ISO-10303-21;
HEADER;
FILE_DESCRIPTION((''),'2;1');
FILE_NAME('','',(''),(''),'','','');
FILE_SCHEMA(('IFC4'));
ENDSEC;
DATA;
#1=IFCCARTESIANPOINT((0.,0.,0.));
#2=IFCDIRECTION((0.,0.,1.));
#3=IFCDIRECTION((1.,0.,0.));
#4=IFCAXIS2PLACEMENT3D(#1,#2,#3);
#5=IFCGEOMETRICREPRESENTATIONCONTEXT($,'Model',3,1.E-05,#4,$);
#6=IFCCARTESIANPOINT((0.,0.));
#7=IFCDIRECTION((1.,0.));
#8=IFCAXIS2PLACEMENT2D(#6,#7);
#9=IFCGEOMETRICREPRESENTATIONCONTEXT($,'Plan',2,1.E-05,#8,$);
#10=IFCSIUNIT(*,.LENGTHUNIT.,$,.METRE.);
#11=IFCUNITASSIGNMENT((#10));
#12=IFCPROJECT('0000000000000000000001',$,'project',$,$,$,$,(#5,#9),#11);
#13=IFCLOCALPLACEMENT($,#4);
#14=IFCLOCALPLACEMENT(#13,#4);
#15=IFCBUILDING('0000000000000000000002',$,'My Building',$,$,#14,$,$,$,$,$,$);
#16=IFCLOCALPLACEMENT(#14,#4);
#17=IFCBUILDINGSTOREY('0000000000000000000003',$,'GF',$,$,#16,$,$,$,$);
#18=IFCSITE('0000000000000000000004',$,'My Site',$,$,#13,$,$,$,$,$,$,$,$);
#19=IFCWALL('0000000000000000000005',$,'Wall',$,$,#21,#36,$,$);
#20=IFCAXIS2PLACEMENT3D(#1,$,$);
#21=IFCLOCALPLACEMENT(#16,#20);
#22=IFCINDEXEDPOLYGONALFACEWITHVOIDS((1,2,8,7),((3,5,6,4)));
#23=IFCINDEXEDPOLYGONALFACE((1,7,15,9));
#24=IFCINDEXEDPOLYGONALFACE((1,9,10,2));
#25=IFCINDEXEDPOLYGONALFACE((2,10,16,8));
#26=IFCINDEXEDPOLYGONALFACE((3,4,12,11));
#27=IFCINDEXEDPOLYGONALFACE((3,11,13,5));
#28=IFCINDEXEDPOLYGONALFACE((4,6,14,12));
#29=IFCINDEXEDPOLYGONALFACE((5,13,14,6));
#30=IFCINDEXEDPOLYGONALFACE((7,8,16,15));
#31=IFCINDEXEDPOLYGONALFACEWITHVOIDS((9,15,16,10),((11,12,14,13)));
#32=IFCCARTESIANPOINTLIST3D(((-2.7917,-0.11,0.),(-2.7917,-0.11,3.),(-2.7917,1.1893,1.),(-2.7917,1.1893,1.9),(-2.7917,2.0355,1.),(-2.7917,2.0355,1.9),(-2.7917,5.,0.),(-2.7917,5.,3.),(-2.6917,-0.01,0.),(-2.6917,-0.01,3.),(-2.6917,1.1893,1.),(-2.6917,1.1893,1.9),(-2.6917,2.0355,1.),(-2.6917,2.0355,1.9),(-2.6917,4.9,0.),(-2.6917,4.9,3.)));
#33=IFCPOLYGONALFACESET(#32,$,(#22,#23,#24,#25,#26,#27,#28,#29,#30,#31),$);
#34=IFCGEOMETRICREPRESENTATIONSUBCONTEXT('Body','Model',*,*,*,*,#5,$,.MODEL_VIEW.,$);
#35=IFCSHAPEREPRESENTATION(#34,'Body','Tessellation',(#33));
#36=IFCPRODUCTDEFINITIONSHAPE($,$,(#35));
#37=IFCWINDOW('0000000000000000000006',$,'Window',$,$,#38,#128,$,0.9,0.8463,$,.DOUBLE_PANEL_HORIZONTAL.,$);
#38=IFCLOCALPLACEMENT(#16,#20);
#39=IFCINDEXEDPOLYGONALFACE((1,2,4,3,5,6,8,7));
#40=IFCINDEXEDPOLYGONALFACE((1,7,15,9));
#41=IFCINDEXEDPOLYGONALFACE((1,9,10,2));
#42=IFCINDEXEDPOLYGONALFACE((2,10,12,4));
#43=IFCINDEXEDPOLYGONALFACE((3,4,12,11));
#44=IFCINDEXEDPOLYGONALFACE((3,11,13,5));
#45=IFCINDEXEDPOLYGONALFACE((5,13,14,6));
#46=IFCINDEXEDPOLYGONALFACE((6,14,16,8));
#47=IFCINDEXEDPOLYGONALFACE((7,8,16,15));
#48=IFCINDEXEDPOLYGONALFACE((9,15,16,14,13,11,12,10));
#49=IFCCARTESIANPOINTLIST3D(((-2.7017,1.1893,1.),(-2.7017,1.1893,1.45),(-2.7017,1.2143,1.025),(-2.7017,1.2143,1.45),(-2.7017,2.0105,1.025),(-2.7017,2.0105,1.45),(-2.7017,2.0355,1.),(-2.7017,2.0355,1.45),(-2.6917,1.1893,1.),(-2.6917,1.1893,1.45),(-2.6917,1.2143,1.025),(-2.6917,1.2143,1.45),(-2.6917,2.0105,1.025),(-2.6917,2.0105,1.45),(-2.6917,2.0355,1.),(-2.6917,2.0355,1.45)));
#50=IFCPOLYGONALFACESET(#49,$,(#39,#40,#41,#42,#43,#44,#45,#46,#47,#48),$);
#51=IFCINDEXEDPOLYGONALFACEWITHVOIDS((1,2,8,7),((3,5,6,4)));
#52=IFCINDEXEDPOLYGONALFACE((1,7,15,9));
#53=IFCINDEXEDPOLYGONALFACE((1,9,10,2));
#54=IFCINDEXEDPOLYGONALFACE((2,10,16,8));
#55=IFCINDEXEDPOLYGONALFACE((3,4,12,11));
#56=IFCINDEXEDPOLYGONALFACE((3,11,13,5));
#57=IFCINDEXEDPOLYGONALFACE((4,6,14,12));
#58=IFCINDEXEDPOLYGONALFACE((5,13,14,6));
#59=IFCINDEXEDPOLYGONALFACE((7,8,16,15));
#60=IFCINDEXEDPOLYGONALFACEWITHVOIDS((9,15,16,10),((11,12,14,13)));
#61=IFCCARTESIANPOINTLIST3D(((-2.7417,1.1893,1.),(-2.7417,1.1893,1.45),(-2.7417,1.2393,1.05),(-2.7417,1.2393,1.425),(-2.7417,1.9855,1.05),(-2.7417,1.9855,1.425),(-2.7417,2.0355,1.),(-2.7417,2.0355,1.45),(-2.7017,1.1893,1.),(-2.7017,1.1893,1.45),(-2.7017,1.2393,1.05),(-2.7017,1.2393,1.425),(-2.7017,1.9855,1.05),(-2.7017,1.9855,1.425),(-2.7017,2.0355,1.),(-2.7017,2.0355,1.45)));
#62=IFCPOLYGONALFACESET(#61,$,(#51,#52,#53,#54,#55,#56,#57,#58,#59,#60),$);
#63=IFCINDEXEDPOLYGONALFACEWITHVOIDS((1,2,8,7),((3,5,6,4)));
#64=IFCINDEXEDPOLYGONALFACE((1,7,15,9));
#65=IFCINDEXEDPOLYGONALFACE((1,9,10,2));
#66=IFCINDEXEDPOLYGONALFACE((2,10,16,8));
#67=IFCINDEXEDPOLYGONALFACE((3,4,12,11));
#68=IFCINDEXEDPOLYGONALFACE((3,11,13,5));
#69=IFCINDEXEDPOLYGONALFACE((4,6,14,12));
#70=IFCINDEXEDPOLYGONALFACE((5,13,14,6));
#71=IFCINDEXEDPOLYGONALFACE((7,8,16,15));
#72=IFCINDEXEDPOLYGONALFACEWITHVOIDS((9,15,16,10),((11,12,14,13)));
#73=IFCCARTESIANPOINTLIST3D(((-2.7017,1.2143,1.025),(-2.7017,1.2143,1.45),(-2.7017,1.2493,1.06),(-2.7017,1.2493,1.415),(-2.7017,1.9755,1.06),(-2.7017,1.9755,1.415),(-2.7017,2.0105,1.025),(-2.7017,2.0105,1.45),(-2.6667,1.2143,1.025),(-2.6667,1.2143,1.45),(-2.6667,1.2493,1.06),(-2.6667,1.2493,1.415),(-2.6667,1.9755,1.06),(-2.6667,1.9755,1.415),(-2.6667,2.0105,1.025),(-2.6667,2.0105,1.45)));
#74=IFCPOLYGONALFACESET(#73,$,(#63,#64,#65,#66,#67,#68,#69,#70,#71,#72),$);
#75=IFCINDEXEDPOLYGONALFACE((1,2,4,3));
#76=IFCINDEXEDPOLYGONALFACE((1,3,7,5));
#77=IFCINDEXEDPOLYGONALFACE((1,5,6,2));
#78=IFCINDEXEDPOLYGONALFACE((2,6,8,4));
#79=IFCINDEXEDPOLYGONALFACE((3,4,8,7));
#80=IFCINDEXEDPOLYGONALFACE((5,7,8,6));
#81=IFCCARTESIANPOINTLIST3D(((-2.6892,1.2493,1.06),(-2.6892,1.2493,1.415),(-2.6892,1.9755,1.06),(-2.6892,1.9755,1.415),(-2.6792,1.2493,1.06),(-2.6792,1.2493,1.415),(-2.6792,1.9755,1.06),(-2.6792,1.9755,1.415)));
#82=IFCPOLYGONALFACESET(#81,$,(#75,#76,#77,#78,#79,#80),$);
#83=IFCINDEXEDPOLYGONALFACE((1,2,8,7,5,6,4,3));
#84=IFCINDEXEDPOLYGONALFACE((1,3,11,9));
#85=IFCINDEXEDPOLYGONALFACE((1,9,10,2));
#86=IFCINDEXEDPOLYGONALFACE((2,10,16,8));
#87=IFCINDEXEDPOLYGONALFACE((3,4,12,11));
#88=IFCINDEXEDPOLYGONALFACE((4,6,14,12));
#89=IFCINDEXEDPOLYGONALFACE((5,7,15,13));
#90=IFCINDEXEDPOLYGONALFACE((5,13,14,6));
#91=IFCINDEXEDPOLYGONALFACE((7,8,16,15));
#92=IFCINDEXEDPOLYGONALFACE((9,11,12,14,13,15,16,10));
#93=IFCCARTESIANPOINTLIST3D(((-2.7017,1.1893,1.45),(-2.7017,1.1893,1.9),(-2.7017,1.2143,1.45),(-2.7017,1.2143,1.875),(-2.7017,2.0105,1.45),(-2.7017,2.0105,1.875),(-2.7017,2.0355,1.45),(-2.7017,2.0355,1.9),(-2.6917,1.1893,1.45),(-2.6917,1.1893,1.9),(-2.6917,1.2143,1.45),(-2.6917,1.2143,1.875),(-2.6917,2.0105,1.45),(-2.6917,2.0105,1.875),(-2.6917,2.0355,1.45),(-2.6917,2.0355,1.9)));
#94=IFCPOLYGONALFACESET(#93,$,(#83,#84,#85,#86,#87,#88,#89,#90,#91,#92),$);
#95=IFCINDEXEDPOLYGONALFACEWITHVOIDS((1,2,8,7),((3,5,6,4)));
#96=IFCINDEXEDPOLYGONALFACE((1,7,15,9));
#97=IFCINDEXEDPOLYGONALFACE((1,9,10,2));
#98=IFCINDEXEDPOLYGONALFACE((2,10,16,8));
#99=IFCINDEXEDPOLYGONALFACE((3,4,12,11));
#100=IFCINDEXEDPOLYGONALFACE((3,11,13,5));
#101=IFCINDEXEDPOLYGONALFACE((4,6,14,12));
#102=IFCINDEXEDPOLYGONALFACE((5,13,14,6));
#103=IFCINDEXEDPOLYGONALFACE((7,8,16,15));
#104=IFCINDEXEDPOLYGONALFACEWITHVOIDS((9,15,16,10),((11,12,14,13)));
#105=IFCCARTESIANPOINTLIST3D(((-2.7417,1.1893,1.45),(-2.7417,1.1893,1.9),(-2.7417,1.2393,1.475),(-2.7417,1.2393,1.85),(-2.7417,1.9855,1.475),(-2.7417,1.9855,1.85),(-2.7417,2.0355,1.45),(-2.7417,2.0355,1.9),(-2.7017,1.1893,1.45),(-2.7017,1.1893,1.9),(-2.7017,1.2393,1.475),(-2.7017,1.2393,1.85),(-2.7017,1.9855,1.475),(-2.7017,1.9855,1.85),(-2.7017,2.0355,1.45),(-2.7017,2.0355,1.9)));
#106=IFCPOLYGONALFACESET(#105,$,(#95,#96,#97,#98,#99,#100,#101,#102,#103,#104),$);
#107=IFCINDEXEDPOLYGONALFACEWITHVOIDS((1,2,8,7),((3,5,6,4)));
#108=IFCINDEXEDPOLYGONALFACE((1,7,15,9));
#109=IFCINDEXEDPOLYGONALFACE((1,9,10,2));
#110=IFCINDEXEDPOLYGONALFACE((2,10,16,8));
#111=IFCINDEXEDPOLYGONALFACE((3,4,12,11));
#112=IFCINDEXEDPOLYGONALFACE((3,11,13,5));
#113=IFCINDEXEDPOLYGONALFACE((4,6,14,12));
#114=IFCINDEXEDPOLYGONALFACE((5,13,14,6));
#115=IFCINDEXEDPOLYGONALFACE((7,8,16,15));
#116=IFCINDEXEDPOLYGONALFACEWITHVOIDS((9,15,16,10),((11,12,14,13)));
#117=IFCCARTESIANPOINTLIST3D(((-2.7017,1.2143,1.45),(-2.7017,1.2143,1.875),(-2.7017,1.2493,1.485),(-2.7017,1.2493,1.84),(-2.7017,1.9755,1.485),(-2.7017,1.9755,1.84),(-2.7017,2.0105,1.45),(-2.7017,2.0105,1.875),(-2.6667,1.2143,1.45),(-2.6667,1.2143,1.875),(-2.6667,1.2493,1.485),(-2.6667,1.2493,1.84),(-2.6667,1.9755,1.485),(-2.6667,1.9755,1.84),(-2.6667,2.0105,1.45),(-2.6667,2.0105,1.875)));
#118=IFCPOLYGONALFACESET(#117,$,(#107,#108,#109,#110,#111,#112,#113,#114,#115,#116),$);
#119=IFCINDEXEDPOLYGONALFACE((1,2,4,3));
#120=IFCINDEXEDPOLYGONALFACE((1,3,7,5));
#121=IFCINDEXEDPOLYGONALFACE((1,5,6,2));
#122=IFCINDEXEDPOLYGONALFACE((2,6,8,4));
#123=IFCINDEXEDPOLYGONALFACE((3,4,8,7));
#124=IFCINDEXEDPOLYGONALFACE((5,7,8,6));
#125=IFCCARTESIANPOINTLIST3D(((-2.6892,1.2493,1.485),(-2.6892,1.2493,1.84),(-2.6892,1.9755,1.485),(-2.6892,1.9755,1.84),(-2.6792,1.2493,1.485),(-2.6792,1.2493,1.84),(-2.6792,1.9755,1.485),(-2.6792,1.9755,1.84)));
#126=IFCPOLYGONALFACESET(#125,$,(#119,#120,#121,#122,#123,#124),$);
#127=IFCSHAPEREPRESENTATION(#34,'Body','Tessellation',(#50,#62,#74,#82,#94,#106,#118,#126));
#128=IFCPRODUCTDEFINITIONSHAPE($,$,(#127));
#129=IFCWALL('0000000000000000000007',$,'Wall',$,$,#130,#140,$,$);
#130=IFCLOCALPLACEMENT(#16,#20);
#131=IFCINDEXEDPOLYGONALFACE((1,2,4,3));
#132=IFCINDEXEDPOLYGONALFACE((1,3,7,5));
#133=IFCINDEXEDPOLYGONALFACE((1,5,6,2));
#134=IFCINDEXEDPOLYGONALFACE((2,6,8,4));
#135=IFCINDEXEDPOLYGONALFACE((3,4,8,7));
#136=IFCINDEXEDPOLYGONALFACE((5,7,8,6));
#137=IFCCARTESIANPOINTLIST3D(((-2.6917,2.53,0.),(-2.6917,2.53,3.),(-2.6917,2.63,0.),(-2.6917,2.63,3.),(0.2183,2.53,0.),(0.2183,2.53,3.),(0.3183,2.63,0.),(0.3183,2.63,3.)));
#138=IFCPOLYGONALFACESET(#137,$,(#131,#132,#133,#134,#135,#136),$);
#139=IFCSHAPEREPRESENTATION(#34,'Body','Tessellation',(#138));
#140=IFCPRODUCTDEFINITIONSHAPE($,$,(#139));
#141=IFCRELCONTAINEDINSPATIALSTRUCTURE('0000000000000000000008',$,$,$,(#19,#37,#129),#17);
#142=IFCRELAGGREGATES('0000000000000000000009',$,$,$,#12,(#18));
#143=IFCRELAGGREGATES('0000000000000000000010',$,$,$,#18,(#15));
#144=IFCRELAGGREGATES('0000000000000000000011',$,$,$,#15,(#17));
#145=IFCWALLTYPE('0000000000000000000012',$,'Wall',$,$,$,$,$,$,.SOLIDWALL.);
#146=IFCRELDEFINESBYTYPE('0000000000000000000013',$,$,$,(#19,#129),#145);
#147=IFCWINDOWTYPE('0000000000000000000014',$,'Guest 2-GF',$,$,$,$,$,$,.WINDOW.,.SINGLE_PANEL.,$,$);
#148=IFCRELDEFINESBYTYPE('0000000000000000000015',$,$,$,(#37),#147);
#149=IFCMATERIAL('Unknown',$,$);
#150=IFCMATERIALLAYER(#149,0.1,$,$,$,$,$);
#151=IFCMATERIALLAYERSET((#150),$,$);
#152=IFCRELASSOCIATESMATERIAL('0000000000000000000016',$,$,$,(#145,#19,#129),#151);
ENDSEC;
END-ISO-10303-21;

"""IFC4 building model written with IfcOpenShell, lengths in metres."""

from ifc_helpers import new_model, entity, si_unit, frame, origin_with_axes, origin_2d_with_axis, place, context, subcontext, project, spatial, line, indexed_curve, outline, extrude, shape, source, transform, mapped, material, layer, layer_set, layer_usage, type_object, type_shapes, element, fill, save


model = new_model("IFC4")

# Units and contexts
model_context = context("Model", 3, precision=1e-05, world=origin_with_axes())
plan_context = context("Plan", 2, precision=1e-05, world=origin_2d_with_axis())
body_context_1 = subcontext(model_context, "Body", "Model", "MODEL_VIEW")
body_context_2 = subcontext(plan_context, "Body", "Plan", "PLAN_VIEW")
ifc_project = project(units=[si_unit("LENGTHUNIT", "METRE")], contexts=[model_context, plan_context])

# Site, building, storey
site_placement = place(None, origin_with_axes())
site = spatial("IfcSite", under=ifc_project, at=site_placement, Name="My Site")
building_placement = place(site_placement, origin_with_axes())
building = spatial("IfcBuilding", under=site, at=building_placement, Name="My Building")
storey_placement = place(building_placement, origin_with_axes())
storey = spatial("IfcBuildingStorey", under=building, at=storey_placement, Name="GF")

# Shared definitions
ifc_material_1 = material(Name="Unknown")
ifc_layer = layer(ifc_material_1, 0.1)
ifc_layer_set = layer_set([ifc_layer])
wall_type = type_object("IfcWallType", Name="Wall", PredefinedType="SOLIDWALL", material=ifc_layer_set)

# Wall, opening, window
ifc_layer_usage_1 = layer_usage(ifc_layer_set, "AXIS2", "POSITIVE", 0.0)
wall_1_placement = place(storey_placement, frame((-2.7917, 5.0, 0.0), z_axis=(0.0, 0.0, 1.0), x_axis=(0.0, -1.0, 0.0)))
wall_1 = element("IfcWall", 1, at=wall_1_placement, inside=storey, type_object=wall_type, material=ifc_layer_usage_1, Name="Wall", context=body_context_1, shape_type="SweptSolid", body=[
    extrude(outline(indexed_curve([(0.0, 0.0), (0.1, 0.1), (5.01, 0.1), (5.11, 0.0)], segments=[line(1, 2, 3, 4, 1)])), origin_with_axes(), (0.0, 0.0, 1.0), 3.0),
])
shared_shape_1 = source(origin_with_axes(), body_context_1, "Body", "SweptSolid", [
    extrude(outline(indexed_curve([(0.0, 0.0), (0.8463, 0.0), (0.8463, 0.9), (0.0, 0.9)], segments=[line(1, 2, 3, 4, 1)])), frame((0.0, -0.6, 0.0), z_axis=(0.0, -1.0, 0.0), x_axis=(1.0, 0.0, 0.0)), (0.0, 0.0, -1.0), 1.2),
])
opening_1_placement = place(wall_1_placement, frame((2.9644, 0.0, 1.0), z_axis=(0.0, 0.0, 1.0), x_axis=(1.0, 0.0, 0.0)))
opening_1 = element("IfcOpeningElement", 2, at=opening_1_placement, cuts=wall_1, PredefinedType="OPENING", context=body_context_1, shape_type="MappedRepresentation", body=[
    mapped(shared_shape_1, transform((0.0, 0.0, 0.0), x_axis=(1.0, 0.0, 0.0), y_axis=(0.0, 1.0, 0.0), z_axis=(0.0, 0.0, 1.0), scale=1.0)),
])
window_type_1 = type_object("IfcWindowType", Name="Guest 2-GF", PartitioningType="SINGLE_PANEL", PredefinedType="WINDOW")
shared_shape_2 = source(origin_with_axes(), body_context_1, "Body", "SweptSolid", [
    extrude(outline(indexed_curve([(0.8463, 0.45), (0.8463, 0.0), (0.0, 0.0), (0.0, 0.45), (0.025, 0.45), (0.025, 0.025), (0.8213, 0.025), (0.8213, 0.45)], segments=[line(1, 2, 3, 4, 5, 6, 7, 8, 1)])), frame((0.0, 0.09, 0.0), z_axis=(0.0, -1.0, 0.0), x_axis=(1.0, 0.0, 0.0)), (0.0, 0.0, -1.0), 0.01),
    extrude(outline(indexed_curve([(0.0, 0.0), (0.8463, 0.0), (0.8463, 0.45), (0.0, 0.45)], segments=[line(1, 2, 3, 4, 1)]), holes=[indexed_curve([(0.05, 0.05), (0.7963, 0.05), (0.7963, 0.425), (0.05, 0.425)], segments=[line(1, 2, 3, 4, 1)])]), frame((0.0, 0.05, 0.0), z_axis=(0.0, -1.0, 0.0), x_axis=(1.0, 0.0, 0.0)), (0.0, 0.0, -1.0), 0.04),
    extrude(outline(indexed_curve([(0.0, 0.0), (0.7963, 0.0), (0.7963, 0.425), (0.0, 0.425)], segments=[line(1, 2, 3, 4, 1)]), holes=[indexed_curve([(0.035, 0.035), (0.7613, 0.035), (0.7613, 0.39), (0.035, 0.39)], segments=[line(1, 2, 3, 4, 1)])]), frame((0.025, 0.09, 0.025), z_axis=(0.0, -1.0, 0.0), x_axis=(1.0, 0.0, 0.0)), (0.0, 0.0, -1.0), 0.035),
    extrude(outline(indexed_curve([(0.035, 0.035), (0.7613, 0.035), (0.7613, 0.39), (0.035, 0.39)], segments=[line(1, 2, 3, 4, 1)])), frame((0.025, 0.1025, 0.025), z_axis=(0.0, -1.0, 0.0), x_axis=(1.0, 0.0, 0.0)), (0.0, 0.0, -1.0), 0.01),
    extrude(outline(indexed_curve([(0.0, 0.0), (0.0, 0.45), (0.8463, 0.45), (0.8463, 0.0), (0.8213, 0.0), (0.8213, 0.425), (0.025, 0.425), (0.025, 0.0)], segments=[line(1, 2, 3, 4, 5, 6, 7, 8, 1)])), frame((0.0, 0.09, 0.45), z_axis=(0.0, -1.0, 0.0), x_axis=(1.0, 0.0, 0.0)), (0.0, 0.0, -1.0), 0.01),
    extrude(outline(indexed_curve([(0.0, 0.0), (0.8463, 0.0), (0.8463, 0.45), (0.0, 0.45)], segments=[line(1, 2, 3, 4, 1)]), holes=[indexed_curve([(0.05, 0.025), (0.7963, 0.025), (0.7963, 0.4), (0.05, 0.4)], segments=[line(1, 2, 3, 4, 1)])]), frame((0.0, 0.05, 0.45), z_axis=(0.0, -1.0, 0.0), x_axis=(1.0, 0.0, 0.0)), (0.0, 0.0, -1.0), 0.04),
    extrude(outline(indexed_curve([(0.0, 0.0), (0.7963, 0.0), (0.7963, 0.425), (0.0, 0.425)], segments=[line(1, 2, 3, 4, 1)]), holes=[indexed_curve([(0.035, 0.035), (0.7613, 0.035), (0.7613, 0.39), (0.035, 0.39)], segments=[line(1, 2, 3, 4, 1)])]), frame((0.025, 0.09, 0.45), z_axis=(0.0, -1.0, 0.0), x_axis=(1.0, 0.0, 0.0)), (0.0, 0.0, -1.0), 0.035),
    extrude(outline(indexed_curve([(0.035, 0.035), (0.7613, 0.035), (0.7613, 0.39), (0.035, 0.39)], segments=[line(1, 2, 3, 4, 1)])), frame((0.025, 0.1025, 0.45), z_axis=(0.0, -1.0, 0.0), x_axis=(1.0, 0.0, 0.0)), (0.0, 0.0, -1.0), 0.01),
])
shared_shape_3 = source(origin_with_axes(), body_context_2, "Body", "Curve2D", [
    entity("IfcIndexedPolyCurve", entity("IfcCartesianPointList2D", [[0.05, 0.05], [0.7963, 0.05]])),
    entity("IfcIndexedPolyCurve", entity("IfcCartesianPointList2D", [[0.0, 0.1], [0.025, 0.1], [0.025, 0.09], [0.05, 0.09], [0.05, 0.05], [0.0, 0.05]]), [entity("IfcLineIndex", [1, 2, 3, 4, 5, 6, 1])]),
    entity("IfcIndexedPolyCurve", entity("IfcCartesianPointList2D", [[0.8463, 0.1], [0.8213, 0.1], [0.8213, 0.09], [0.7963, 0.09], [0.7963, 0.05], [0.8463, 0.05]]), [entity("IfcLineIndex", [1, 2, 3, 4, 5, 6, 1])]),
    entity("IfcIndexedPolyCurve", entity("IfcCartesianPointList2D", [[0.025, 0.09], [0.06, 0.09], [0.06, 0.125], [0.025, 0.125]]), [entity("IfcLineIndex", [1, 2, 3, 4, 1])]),
    entity("IfcIndexedPolyCurve", entity("IfcCartesianPointList2D", [[0.8213, 0.09], [0.7863, 0.09], [0.7863, 0.125], [0.8213, 0.125]]), [entity("IfcLineIndex", [1, 2, 3, 4, 1])]),
    entity("IfcIndexedPolyCurve", entity("IfcCartesianPointList2D", [[0.06, 0.09], [0.7863, 0.09]])),
    entity("IfcIndexedPolyCurve", entity("IfcCartesianPointList2D", [[0.06, 0.125], [0.7863, 0.125]])),
    entity("IfcIndexedPolyCurve", entity("IfcCartesianPointList2D", [[0.06, 0.1075], [0.7863, 0.1075]])),
])
type_shapes(window_type_1, [shared_shape_2, shared_shape_3])
window_1_placement = place(opening_1_placement, frame((0.0, 0.0, 0.0), z_axis=(0.0, 0.0, 1.0), x_axis=(1.0, 0.0, 0.0)))
window_1 = element("IfcWindow", 3, at=window_1_placement, inside=storey, type_object=window_type_1, Name="Window", OverallHeight=0.9, OverallWidth=0.8463, PartitioningType="DOUBLE_PANEL_HORIZONTAL", shapes=[
    shape(body_context_1, "Body", "MappedRepresentation", [mapped(shared_shape_2, transform((0.0, 0.0, 0.0), x_axis=(1.0, 0.0, 0.0), y_axis=(0.0, 1.0, 0.0), z_axis=(0.0, 0.0, 1.0), scale=1.0))]),
    shape(body_context_2, "Body", "MappedRepresentation", [mapped(shared_shape_3, transform((0.0, 0.0, 0.0), x_axis=(1.0, 0.0, 0.0), y_axis=(0.0, 1.0, 0.0), z_axis=(0.0, 0.0, 1.0), scale=1.0))]),
])
fill(opening_1, window_1)

# Wall
ifc_layer_usage_2 = layer_usage(ifc_layer_set, "AXIS2", "POSITIVE", 0.0)
wall_2_placement = place(storey_placement, frame((0.3183, 2.63, 0.0), z_axis=(0.0, 0.0, 1.0), x_axis=(-1.0, 0.0, 0.0)))
element("IfcWall", 4, at=wall_2_placement, inside=storey, type_object=wall_type, material=ifc_layer_usage_2, Name="Wall", context=body_context_1, shape_type="SweptSolid", body=[
    extrude(outline(indexed_curve([(0.0, 0.0), (0.1, 0.1), (3.01, 0.1), (3.01, 0.0)], segments=[line(1, 2, 3, 4, 1)])), origin_with_axes(), (0.0, 0.0, 1.0), 3.0),
])

save(model, "model.ifc")
